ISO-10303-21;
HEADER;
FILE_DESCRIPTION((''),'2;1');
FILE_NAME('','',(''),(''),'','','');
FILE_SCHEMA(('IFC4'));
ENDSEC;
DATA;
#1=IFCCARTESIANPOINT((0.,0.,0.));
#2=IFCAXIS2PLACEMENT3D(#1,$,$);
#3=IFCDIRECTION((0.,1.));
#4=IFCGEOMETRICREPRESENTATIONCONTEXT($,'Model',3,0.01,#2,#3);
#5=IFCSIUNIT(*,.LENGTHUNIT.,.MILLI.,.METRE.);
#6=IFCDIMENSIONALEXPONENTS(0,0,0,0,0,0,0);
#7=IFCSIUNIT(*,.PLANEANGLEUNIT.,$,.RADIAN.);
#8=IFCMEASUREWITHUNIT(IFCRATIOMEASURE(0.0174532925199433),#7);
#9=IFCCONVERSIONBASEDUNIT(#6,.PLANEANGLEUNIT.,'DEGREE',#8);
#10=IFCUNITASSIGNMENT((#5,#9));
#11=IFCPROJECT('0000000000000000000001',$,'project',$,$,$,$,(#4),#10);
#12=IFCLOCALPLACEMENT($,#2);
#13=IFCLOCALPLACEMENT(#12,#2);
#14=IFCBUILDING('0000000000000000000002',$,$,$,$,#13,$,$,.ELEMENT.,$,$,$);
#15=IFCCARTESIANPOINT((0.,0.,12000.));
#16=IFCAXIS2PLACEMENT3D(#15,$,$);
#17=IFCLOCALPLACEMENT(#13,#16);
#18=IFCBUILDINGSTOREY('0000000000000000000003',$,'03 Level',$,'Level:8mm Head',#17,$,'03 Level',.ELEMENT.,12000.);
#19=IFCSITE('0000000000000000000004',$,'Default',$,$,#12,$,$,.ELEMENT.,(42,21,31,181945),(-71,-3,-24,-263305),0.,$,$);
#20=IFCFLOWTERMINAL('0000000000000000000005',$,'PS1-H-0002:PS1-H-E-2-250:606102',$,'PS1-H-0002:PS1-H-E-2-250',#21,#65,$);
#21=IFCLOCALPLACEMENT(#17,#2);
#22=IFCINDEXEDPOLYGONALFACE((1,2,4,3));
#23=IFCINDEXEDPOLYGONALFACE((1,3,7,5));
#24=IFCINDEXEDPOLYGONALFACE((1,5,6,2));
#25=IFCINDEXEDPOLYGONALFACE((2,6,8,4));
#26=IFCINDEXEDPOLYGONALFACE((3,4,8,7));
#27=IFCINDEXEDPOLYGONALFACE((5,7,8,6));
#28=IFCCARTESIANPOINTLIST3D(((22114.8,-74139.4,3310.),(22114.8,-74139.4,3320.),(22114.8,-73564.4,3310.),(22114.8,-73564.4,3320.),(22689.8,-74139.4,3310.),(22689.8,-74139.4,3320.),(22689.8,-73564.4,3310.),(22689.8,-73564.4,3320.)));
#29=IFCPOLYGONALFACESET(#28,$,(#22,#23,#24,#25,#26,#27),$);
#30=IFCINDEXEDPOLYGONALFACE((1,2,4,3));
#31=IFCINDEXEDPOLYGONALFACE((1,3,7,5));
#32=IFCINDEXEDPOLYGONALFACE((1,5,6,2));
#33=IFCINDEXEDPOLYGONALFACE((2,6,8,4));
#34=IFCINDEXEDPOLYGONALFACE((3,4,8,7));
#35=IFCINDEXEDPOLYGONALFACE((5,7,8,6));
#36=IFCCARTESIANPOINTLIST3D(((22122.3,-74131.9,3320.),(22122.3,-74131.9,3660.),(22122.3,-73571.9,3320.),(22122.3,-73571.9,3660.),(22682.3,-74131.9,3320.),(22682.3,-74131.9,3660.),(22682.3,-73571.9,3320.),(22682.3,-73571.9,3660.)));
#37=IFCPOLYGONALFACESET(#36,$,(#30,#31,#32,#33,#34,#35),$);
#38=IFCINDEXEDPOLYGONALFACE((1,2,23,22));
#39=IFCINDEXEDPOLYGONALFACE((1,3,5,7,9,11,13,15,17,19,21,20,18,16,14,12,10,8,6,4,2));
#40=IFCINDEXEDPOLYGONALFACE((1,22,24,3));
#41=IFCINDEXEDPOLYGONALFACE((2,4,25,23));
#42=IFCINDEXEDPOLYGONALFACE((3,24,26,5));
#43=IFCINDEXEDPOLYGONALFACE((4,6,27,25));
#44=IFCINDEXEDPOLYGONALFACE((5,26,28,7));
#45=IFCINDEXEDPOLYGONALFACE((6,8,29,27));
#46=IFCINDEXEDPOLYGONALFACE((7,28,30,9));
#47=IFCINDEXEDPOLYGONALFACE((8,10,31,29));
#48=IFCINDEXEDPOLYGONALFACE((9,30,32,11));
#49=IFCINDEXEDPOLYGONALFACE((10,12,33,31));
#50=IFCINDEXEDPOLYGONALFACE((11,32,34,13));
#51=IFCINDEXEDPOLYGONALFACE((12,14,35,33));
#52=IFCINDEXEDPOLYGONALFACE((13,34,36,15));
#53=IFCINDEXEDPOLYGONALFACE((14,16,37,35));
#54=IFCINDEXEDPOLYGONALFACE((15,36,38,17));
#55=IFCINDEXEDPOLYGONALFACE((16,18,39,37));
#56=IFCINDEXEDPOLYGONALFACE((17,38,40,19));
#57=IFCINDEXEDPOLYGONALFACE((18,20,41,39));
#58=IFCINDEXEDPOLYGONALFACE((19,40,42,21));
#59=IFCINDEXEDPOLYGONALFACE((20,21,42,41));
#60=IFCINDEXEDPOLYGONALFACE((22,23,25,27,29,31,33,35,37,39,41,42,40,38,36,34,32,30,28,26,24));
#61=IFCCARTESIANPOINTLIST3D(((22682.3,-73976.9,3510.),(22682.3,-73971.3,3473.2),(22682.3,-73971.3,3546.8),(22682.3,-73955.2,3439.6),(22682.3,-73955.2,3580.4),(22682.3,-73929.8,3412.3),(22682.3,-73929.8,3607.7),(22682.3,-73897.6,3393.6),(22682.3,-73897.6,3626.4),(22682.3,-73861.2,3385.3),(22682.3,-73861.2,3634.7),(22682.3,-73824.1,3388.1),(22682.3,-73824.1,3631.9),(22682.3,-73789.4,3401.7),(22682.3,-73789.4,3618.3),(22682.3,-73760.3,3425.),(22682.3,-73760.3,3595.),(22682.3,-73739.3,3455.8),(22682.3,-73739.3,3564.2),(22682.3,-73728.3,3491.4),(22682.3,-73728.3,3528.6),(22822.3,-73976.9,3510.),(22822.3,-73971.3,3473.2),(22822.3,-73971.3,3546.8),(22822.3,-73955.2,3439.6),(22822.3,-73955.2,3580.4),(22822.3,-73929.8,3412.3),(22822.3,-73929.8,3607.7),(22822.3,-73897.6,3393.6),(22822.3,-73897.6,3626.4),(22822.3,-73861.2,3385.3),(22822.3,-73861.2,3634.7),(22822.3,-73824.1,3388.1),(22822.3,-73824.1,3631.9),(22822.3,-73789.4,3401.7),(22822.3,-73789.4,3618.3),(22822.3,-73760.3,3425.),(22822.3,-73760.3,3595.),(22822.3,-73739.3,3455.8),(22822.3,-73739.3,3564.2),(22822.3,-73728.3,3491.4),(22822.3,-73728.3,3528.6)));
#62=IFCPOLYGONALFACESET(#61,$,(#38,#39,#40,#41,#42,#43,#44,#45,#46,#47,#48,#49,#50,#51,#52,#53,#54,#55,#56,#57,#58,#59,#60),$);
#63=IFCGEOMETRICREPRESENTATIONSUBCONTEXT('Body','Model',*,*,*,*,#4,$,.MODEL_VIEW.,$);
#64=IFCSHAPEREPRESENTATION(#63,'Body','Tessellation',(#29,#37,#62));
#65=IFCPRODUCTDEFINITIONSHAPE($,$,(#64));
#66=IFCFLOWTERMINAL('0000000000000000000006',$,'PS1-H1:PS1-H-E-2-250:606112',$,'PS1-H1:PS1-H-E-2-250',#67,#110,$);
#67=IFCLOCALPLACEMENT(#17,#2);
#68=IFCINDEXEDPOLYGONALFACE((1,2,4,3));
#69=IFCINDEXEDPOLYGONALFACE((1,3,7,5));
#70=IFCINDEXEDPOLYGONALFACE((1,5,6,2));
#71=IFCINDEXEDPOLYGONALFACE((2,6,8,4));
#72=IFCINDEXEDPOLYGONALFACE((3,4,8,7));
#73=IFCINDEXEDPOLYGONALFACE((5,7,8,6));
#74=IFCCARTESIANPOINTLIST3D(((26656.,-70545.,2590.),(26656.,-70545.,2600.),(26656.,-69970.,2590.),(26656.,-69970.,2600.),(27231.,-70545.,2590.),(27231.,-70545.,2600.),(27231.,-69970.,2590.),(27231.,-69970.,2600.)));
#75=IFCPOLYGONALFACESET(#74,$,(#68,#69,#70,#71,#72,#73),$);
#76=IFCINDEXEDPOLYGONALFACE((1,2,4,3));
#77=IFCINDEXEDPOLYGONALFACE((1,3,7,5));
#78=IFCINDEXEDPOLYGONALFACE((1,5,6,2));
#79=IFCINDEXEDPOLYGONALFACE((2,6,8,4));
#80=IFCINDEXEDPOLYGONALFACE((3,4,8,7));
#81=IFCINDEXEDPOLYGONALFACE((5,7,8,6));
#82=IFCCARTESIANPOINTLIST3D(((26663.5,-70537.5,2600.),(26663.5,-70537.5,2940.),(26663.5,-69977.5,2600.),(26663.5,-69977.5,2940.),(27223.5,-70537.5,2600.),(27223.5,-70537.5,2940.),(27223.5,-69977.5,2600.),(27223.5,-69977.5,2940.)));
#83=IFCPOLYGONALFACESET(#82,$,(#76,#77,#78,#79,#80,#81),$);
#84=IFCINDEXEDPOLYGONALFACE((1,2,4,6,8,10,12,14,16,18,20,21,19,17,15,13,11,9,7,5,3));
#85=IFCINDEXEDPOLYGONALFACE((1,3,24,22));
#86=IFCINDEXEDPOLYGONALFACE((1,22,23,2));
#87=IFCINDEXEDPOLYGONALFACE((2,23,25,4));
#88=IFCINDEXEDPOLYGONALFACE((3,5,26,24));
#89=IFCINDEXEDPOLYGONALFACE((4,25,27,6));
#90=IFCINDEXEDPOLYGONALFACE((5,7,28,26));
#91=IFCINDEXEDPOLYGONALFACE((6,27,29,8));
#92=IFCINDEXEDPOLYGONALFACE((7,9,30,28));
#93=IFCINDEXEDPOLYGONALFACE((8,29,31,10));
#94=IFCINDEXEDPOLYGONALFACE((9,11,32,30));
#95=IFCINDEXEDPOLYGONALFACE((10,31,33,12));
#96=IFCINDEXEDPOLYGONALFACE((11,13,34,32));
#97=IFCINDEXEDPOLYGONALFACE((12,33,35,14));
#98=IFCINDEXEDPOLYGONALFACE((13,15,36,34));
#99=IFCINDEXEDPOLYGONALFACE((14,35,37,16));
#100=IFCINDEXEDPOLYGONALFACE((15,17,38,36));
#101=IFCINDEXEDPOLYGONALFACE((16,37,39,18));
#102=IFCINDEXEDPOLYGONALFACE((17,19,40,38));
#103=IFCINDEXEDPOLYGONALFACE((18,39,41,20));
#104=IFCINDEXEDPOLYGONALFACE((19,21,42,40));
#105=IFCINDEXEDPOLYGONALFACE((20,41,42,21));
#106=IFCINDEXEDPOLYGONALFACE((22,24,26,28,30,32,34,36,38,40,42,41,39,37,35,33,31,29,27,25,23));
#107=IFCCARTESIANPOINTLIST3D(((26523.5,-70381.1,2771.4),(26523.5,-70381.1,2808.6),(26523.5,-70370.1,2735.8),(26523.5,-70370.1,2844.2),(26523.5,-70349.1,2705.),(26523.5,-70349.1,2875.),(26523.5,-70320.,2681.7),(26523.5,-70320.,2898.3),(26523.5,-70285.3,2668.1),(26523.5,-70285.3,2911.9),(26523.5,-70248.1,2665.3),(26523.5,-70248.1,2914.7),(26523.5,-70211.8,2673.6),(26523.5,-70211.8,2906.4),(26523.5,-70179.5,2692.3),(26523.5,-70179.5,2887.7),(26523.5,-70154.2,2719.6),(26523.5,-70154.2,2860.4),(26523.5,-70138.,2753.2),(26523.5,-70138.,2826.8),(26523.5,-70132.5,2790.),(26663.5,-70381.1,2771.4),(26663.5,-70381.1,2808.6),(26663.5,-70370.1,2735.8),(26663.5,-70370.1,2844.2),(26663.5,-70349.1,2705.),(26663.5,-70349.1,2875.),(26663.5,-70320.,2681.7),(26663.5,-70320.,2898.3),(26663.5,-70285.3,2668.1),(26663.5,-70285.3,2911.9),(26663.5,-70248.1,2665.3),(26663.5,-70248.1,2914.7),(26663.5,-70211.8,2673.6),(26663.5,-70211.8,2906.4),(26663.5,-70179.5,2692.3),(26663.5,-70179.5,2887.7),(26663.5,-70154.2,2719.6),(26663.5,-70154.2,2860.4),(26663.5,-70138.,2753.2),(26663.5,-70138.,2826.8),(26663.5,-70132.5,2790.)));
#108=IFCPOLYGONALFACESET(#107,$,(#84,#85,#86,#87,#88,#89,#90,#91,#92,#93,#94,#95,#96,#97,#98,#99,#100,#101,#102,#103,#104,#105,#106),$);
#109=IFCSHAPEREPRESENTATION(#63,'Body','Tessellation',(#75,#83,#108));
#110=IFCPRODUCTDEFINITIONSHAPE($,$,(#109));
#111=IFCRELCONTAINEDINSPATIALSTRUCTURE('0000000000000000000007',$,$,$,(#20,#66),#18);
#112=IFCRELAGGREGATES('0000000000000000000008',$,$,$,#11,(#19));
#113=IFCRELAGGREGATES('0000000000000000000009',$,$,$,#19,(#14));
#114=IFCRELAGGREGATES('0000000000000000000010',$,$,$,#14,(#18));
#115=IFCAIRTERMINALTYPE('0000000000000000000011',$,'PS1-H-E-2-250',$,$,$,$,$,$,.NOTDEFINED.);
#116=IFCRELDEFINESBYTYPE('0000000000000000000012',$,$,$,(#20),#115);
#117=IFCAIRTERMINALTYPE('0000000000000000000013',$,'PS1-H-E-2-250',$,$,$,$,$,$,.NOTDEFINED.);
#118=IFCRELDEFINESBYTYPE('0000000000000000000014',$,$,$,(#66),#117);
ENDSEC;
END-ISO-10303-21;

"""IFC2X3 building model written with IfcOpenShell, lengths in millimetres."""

from ifc_helpers import new_model, entity, si_unit, converted_unit, direction, frame, frame_2d, origin, origin_2d_with_axis, place, context, subcontext, project, spatial, rectangle, circle, extrude, source, transform, mapped, type_object, type_shapes, element, save


model = new_model("IFC2X3")

# Units and contexts
model_context = context("Model", 3, precision=0.01, world=origin(), true_north=direction((0.0, 1.0)))
body_context = subcontext(model_context, "Body", "Model", "MODEL_VIEW")
ifc_project = project(units=[si_unit("LENGTHUNIT", "METRE", prefix="MILLI"), converted_unit("PLANEANGLEUNIT", "DEGREE", entity("IfcRatioMeasure", 0.0174532925199433), si_unit("PLANEANGLEUNIT", "RADIAN"), dimensions=[0, 0, 0, 0, 0, 0, 0])], contexts=[model_context])

# Site, building, storey
site_placement = place(None, origin())
site = spatial("IfcSite", under=ifc_project, at=site_placement, Name="Default", CompositionType="ELEMENT", RefLatitude=(42, 21, 31, 181945), RefLongitude=(-71, -3, -24, -263305), RefElevation=0.0)
building_placement = place(site_placement, origin())
building = spatial("IfcBuilding", under=site, at=building_placement, CompositionType="ELEMENT")
storey_placement = place(building_placement, frame((0.0, 0.0, 12000.0)))
storey = spatial("IfcBuildingStorey", under=building, at=storey_placement, Name="03 Level", ObjectType="Level:8mm Head", LongName="03 Level", CompositionType="ELEMENT", Elevation=12000.0)

# Flow terminals
air_terminal_type_1 = type_object("IfcAirTerminalType", Name="PS1-H-E-2-250", PredefinedType="NOTDEFINED")
shared_shape_1 = source(origin(), body_context, "Body", "SweptSolid", [
    extrude(rectangle(XDim=575.0, YDim=575.0, at=origin_2d_with_axis()), frame((0.0, 0.0, -10.0), z_axis=(0.0, 0.0, 1.0), x_axis=(-1.0, 0.0, 0.0)), (0.0, 0.0, 1.0), 10.0),
    extrude(rectangle(XDim=560.0, YDim=560.0, at=origin_2d_with_axis()), frame((0.0, 0.0, 0.0), z_axis=(0.0, 0.0, 1.0), x_axis=(-1.0, 0.0, 0.0)), (0.0, 0.0, 1.0), 340.0),
    extrude(circle(Radius=125.0, at=frame_2d((0.0, 0.0), x_axis=(1.0, 0.0))), frame((-420.0, 0.0, 190.0), z_axis=(1.0, 0.0, 0.0), x_axis=(0.0, 1.0, 0.0)), (0.0, 0.0, 1.0), 140.0),
])
type_shapes(air_terminal_type_1, [shared_shape_1])
flow_terminal_1_placement = place(storey_placement, frame((22402.3, -73851.9, 3320.0), z_axis=(0.0, 0.0, 1.0), x_axis=(-1.0, 0.0, 0.0)))
element("IfcFlowTerminal", 1, at=flow_terminal_1_placement, inside=storey, type_object=air_terminal_type_1, Name="PS1-H-0002:PS1-H-E-2-250:606102", ObjectType="PS1-H-0002:PS1-H-E-2-250", context=body_context, shape_type="MappedRepresentation", body=[
    mapped(shared_shape_1, transform((0.0, 0.0, 0.0), scale=1.0)),
])
air_terminal_type_2 = type_object("IfcAirTerminalType", Name="PS1-H-E-2-250", PredefinedType="NOTDEFINED")
shared_shape_2 = source(origin(), body_context, "Body", "SweptSolid", [
    extrude(rectangle(XDim=575.0, YDim=575.0, at=origin_2d_with_axis()), frame((0.0, 0.0, -10.0), z_axis=(0.0, 0.0, 1.0), x_axis=(-1.0, 0.0, 0.0)), (0.0, 0.0, 1.0), 10.0),
    extrude(rectangle(XDim=560.0, YDim=560.0, at=origin_2d_with_axis()), frame((0.0, 0.0, 0.0), z_axis=(0.0, 0.0, 1.0), x_axis=(-1.0, 0.0, 0.0)), (0.0, 0.0, 1.0), 340.0),
    extrude(circle(Radius=125.0, at=frame_2d((0.0, 0.0), x_axis=(1.0, 0.0))), frame((-420.0, 0.0, 190.0), z_axis=(1.0, 0.0, 0.0), x_axis=(0.0, 1.0, 0.0)), (0.0, 0.0, 1.0), 140.0),
])
type_shapes(air_terminal_type_2, [shared_shape_2])
flow_terminal_2_placement = place(storey_placement, frame((26943.5, -70257.5, 2600.0)))
element("IfcFlowTerminal", 2, at=flow_terminal_2_placement, inside=storey, type_object=air_terminal_type_2, Name="PS1-H1:PS1-H-E-2-250:606112", ObjectType="PS1-H1:PS1-H-E-2-250", context=body_context, shape_type="MappedRepresentation", body=[
    mapped(shared_shape_2, transform((0.0, 0.0, 0.0), scale=1.0)),
])

save(model, "model.ifc")
